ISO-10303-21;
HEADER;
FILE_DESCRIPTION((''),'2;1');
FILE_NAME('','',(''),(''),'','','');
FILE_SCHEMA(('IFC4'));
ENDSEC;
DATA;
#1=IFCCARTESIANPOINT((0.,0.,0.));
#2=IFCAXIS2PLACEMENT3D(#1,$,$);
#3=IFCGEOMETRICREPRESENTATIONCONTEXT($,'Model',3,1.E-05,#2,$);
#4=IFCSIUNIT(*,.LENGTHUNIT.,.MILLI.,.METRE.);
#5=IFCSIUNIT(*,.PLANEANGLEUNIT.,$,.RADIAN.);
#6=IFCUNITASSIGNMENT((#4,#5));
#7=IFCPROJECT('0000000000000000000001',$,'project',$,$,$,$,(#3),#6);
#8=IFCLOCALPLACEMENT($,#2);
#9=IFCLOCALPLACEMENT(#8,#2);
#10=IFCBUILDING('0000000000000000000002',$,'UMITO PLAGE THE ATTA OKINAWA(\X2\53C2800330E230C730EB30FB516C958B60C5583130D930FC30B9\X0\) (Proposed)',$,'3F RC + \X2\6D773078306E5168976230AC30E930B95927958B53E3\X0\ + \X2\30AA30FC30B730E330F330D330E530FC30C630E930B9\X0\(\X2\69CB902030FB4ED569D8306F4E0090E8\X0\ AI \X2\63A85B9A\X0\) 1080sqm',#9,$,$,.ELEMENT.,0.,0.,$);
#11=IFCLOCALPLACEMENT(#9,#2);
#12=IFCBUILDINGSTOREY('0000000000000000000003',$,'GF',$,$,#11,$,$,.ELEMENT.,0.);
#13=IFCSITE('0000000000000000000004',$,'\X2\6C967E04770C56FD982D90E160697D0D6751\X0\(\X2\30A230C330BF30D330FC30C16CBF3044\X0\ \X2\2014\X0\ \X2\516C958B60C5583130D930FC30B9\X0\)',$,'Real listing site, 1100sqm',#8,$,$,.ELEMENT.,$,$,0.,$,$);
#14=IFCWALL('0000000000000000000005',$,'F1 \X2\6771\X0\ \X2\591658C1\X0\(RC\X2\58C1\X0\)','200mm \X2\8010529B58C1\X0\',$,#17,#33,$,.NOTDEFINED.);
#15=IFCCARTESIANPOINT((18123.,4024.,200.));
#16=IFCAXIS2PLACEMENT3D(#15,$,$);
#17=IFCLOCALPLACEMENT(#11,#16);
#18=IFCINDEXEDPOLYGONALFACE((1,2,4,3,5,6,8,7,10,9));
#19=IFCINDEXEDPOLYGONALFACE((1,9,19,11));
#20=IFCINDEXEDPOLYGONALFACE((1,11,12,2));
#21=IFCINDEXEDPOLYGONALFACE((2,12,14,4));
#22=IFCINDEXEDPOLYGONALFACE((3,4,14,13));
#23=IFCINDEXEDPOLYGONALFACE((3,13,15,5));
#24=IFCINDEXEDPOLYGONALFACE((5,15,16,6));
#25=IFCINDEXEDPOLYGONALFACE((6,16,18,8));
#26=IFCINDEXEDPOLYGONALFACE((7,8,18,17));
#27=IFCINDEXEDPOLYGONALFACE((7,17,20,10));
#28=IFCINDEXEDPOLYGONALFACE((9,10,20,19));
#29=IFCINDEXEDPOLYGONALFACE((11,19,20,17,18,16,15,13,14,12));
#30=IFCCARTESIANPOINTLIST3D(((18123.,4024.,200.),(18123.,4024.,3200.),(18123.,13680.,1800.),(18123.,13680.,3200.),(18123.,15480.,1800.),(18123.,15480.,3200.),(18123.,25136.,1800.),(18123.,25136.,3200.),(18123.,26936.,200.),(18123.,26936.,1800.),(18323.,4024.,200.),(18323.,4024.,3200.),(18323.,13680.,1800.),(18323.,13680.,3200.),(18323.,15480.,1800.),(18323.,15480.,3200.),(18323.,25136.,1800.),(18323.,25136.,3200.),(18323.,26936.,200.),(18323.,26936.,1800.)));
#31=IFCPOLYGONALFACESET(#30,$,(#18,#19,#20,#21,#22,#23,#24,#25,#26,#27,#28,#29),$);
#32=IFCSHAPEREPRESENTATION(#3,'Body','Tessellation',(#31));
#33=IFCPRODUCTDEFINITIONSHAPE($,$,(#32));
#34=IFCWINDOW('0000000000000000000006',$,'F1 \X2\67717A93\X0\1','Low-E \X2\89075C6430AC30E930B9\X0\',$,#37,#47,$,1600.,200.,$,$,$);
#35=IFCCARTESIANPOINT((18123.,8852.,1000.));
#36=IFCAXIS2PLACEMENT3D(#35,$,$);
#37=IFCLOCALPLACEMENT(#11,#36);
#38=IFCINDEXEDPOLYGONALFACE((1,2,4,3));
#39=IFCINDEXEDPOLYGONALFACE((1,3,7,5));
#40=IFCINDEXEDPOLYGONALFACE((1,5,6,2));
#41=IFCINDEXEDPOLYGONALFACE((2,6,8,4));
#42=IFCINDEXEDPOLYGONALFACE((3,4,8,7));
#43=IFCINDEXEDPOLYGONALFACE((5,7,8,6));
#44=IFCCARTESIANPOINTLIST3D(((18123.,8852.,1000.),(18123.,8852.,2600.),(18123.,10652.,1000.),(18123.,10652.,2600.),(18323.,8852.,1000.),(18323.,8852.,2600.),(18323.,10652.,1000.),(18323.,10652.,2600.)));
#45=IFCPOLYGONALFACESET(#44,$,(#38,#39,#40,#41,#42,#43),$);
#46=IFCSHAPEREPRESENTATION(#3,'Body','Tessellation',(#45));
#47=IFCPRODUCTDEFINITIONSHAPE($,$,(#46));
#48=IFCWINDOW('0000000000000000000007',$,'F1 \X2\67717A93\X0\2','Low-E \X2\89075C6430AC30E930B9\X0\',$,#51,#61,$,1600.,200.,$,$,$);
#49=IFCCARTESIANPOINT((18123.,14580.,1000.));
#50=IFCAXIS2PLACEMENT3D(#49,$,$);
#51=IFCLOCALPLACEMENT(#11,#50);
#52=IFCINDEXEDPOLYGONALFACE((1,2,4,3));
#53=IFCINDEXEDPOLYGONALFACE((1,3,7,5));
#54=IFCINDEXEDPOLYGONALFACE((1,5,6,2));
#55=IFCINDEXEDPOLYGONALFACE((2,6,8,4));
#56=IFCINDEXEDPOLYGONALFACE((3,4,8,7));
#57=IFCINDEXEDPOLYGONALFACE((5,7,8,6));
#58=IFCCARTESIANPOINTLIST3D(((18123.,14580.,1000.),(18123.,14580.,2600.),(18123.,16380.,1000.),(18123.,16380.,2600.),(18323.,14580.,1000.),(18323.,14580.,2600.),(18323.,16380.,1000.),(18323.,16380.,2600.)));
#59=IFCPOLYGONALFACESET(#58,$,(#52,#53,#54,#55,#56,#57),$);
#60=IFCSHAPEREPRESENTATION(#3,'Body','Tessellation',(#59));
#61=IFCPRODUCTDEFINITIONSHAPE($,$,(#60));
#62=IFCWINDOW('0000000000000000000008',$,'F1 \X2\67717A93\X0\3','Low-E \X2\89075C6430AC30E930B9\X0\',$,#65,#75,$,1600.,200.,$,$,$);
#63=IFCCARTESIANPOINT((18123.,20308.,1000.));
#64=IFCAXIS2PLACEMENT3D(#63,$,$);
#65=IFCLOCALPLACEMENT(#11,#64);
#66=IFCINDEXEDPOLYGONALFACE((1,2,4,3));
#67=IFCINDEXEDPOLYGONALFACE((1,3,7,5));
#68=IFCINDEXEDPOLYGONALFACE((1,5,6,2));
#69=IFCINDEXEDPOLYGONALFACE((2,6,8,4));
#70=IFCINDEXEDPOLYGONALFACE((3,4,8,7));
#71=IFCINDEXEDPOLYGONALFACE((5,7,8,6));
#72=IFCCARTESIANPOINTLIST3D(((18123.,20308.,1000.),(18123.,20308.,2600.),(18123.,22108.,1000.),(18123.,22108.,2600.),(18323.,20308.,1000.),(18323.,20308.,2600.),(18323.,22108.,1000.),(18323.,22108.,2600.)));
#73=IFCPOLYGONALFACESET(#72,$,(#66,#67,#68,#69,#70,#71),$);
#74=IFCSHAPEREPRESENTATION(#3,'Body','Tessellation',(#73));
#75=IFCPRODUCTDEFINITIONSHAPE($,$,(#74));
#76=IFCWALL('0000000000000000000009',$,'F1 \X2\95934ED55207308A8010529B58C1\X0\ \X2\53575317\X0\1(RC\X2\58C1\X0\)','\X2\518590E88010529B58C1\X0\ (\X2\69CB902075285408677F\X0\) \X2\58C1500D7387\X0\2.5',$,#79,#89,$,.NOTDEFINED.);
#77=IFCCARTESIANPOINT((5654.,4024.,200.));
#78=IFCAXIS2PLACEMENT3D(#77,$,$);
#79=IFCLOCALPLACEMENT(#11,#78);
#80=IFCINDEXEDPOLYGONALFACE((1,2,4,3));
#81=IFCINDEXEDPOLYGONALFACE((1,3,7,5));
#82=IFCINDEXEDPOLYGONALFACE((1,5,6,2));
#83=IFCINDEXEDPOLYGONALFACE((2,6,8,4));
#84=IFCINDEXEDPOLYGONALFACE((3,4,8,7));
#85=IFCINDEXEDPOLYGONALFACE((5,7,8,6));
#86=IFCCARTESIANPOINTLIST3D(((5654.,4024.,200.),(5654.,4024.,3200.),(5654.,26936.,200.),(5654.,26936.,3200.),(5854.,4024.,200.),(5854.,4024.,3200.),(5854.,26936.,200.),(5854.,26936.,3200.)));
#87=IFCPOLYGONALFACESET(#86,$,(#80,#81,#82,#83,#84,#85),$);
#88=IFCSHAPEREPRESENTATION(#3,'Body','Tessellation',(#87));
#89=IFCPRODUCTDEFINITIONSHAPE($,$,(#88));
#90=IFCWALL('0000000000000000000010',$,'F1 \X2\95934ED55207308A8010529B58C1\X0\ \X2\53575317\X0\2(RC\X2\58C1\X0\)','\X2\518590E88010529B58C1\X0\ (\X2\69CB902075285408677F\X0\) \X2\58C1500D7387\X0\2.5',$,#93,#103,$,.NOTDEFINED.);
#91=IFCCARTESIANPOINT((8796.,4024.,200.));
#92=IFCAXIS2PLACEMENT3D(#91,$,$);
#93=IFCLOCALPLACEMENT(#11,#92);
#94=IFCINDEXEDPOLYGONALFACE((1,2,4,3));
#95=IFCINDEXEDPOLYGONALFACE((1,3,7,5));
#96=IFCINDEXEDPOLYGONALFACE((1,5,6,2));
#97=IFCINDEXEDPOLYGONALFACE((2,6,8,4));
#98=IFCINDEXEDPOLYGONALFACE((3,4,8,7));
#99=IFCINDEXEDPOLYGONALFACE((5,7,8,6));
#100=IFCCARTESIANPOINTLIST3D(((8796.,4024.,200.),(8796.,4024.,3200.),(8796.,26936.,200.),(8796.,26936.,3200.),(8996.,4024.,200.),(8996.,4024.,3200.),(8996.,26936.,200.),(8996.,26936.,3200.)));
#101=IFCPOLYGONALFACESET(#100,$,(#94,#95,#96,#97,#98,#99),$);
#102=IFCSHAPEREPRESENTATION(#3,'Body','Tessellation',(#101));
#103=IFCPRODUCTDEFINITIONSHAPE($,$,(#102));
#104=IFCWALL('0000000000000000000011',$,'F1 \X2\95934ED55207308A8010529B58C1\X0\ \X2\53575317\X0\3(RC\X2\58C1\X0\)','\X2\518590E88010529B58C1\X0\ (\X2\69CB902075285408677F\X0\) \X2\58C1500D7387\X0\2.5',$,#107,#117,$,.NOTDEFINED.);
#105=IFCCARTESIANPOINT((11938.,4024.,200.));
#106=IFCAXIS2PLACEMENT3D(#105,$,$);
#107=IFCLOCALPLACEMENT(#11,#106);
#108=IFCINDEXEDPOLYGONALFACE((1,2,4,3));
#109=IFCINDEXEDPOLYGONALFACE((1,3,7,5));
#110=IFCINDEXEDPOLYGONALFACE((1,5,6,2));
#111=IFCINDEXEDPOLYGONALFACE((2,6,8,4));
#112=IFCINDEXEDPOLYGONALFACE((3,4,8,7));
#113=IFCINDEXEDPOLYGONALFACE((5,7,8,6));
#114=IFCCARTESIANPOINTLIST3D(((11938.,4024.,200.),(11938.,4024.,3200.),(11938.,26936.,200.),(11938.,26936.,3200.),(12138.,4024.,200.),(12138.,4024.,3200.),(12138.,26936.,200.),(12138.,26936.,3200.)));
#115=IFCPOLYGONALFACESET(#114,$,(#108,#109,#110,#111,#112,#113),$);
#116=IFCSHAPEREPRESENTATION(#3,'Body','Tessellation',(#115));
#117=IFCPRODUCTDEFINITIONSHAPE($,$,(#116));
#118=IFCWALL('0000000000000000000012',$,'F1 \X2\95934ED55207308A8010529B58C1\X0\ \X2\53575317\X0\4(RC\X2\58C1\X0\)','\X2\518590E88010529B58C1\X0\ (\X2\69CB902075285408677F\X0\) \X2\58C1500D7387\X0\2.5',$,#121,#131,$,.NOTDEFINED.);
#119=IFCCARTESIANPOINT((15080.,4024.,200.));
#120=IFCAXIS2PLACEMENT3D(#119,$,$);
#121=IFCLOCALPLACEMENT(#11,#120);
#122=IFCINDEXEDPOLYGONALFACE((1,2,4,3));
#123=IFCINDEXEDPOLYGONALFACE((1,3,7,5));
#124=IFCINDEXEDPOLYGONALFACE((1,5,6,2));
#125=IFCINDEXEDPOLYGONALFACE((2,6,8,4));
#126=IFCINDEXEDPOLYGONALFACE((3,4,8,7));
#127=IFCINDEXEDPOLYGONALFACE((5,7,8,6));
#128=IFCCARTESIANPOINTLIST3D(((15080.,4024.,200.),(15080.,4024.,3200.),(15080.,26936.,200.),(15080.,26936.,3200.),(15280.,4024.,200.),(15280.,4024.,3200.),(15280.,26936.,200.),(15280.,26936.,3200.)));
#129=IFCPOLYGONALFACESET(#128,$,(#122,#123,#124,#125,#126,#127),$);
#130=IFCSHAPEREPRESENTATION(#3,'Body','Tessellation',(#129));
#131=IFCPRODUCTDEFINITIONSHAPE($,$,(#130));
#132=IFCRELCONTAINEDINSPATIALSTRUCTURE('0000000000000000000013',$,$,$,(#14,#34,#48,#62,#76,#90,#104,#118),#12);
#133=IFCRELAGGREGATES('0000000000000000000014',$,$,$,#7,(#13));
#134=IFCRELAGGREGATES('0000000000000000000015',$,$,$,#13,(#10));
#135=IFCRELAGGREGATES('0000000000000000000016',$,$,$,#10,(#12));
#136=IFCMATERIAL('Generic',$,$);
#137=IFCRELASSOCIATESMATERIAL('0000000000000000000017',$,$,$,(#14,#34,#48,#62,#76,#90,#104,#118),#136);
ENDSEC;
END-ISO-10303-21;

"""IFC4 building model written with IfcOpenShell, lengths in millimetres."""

from ifc_helpers import new_model, si_unit, frame, frame_2d, origin, place, context, project, spatial, rectangle, extrude, material, element, fill, save


model = new_model("IFC4")

# Units and contexts
model_context = context("Model", 3, precision=1e-05, world=origin())
ifc_project = project(units=[si_unit("LENGTHUNIT", "METRE", prefix="MILLI"), si_unit("PLANEANGLEUNIT", "RADIAN")], contexts=[model_context])

# Site, building, storey
site_placement = place(None, origin())
site = spatial("IfcSite", under=ifc_project, at=site_placement, Name="沖縄県国頭郡恩納村(アッタビーチ沿い — 公開情報ベース)", ObjectType="Real listing site, 1100sqm", CompositionType="ELEMENT", RefElevation=0.0)
building_placement = place(site_placement, origin())
building = spatial("IfcBuilding", under=site, at=building_placement, Name="UMITO PLAGE THE ATTA OKINAWA(参考モデル・公開情報ベース) (Proposed)", ObjectType="3F RC + 海への全面ガラス大開口 + オーシャンビューテラス(構造・仕様は一部 AI 推定) 1080sqm", CompositionType="ELEMENT", ElevationOfRefHeight=0.0, ElevationOfTerrain=0.0)
storey_placement = place(building_placement, origin())
storey = spatial("IfcBuildingStorey", under=building, at=storey_placement, Name="GF", CompositionType="ELEMENT", Elevation=0.0)

# Wall, openings, windows
ifc_material = material(Name="Generic")
wall_1_placement = place(storey_placement, frame((18123.0, 4024.0, 200.0)))
wall_1 = element("IfcWall", 1, at=wall_1_placement, inside=storey, material=ifc_material, Name="F1 東 外壁(RC壁)", Description="200mm 耐力壁", PredefinedType="NOTDEFINED", context=model_context, shape_type="SweptSolid", body=[
    extrude(rectangle(XDim=200.0, YDim=22912.0, at=frame_2d((100.0, 11456.0))), frame((18123.0, 4024.0, 200.0)), (0.0, 0.0, 1.0), 3000.0),
])
opening_1_placement = place(storey_placement, frame((18123.0, 8852.0, 1000.0)))
opening_1 = element("IfcOpeningElement", 2, at=opening_1_placement, cuts=wall_1, PredefinedType="NOTDEFINED", context=model_context, shape_type="SweptSolid", body=[
    extrude(rectangle(XDim=200.0, YDim=1800.0, at=frame_2d((100.0, 900.0))), frame((18123.0, 8852.0, 1000.0)), (0.0, 0.0, 1.0), 1600.0),
])
opening_2_placement = place(storey_placement, frame((18123.0, 14580.0, 1000.0)))
opening_2 = element("IfcOpeningElement", 3, at=opening_2_placement, cuts=wall_1, PredefinedType="NOTDEFINED", context=model_context, shape_type="SweptSolid", body=[
    extrude(rectangle(XDim=200.0, YDim=1800.0, at=frame_2d((100.0, 900.0))), frame((18123.0, 14580.0, 1000.0)), (0.0, 0.0, 1.0), 1600.0),
])
opening_3_placement = place(storey_placement, frame((18123.0, 20308.0, 1000.0)))
opening_3 = element("IfcOpeningElement", 4, at=opening_3_placement, cuts=wall_1, PredefinedType="NOTDEFINED", context=model_context, shape_type="SweptSolid", body=[
    extrude(rectangle(XDim=200.0, YDim=1800.0, at=frame_2d((100.0, 900.0))), frame((18123.0, 20308.0, 1000.0)), (0.0, 0.0, 1.0), 1600.0),
])
window_1_placement = place(storey_placement, frame((18123.0, 8852.0, 1000.0)))
window_1 = element("IfcWindow", 5, at=window_1_placement, inside=storey, material=ifc_material, Name="F1 東窓1", Description="Low-E 複層ガラス", OverallHeight=1600.0, OverallWidth=200.0, context=model_context, shape_type="SweptSolid", body=[
    extrude(rectangle(XDim=200.0, YDim=1800.0, at=frame_2d((100.0, 900.0))), frame((18123.0, 8852.0, 1000.0)), (0.0, 0.0, 1.0), 1600.0),
])
fill(opening_1, window_1)
window_2_placement = place(storey_placement, frame((18123.0, 14580.0, 1000.0)))
window_2 = element("IfcWindow", 6, at=window_2_placement, inside=storey, material=ifc_material, Name="F1 東窓2", Description="Low-E 複層ガラス", OverallHeight=1600.0, OverallWidth=200.0, context=model_context, shape_type="SweptSolid", body=[
    extrude(rectangle(XDim=200.0, YDim=1800.0, at=frame_2d((100.0, 900.0))), frame((18123.0, 14580.0, 1000.0)), (0.0, 0.0, 1.0), 1600.0),
])
fill(opening_2, window_2)
window_3_placement = place(storey_placement, frame((18123.0, 20308.0, 1000.0)))
window_3 = element("IfcWindow", 7, at=window_3_placement, inside=storey, material=ifc_material, Name="F1 東窓3", Description="Low-E 複層ガラス", OverallHeight=1600.0, OverallWidth=200.0, context=model_context, shape_type="SweptSolid", body=[
    extrude(rectangle(XDim=200.0, YDim=1800.0, at=frame_2d((100.0, 900.0))), frame((18123.0, 20308.0, 1000.0)), (0.0, 0.0, 1.0), 1600.0),
])
fill(opening_3, window_3)

# Walls
wall_2_placement = place(storey_placement, frame((5654.0, 4024.0, 200.0)))
element("IfcWall", 8, at=wall_2_placement, inside=storey, material=ifc_material, Name="F1 間仕切り耐力壁 南北1(RC壁)", Description="内部耐力壁 (構造用合板) 壁倍率2.5", PredefinedType="NOTDEFINED", context=model_context, shape_type="SweptSolid", body=[
    extrude(rectangle(XDim=200.0, YDim=22912.0, at=frame_2d((100.0, 11456.0))), frame((5654.0, 4024.0, 200.0)), (0.0, 0.0, 1.0), 3000.0),
])
wall_3_placement = place(storey_placement, frame((8796.0, 4024.0, 200.0)))
element("IfcWall", 9, at=wall_3_placement, inside=storey, material=ifc_material, Name="F1 間仕切り耐力壁 南北2(RC壁)", Description="内部耐力壁 (構造用合板) 壁倍率2.5", PredefinedType="NOTDEFINED", context=model_context, shape_type="SweptSolid", body=[
    extrude(rectangle(XDim=200.0, YDim=22912.0, at=frame_2d((100.0, 11456.0))), frame((8796.0, 4024.0, 200.0)), (0.0, 0.0, 1.0), 3000.0),
])
wall_4_placement = place(storey_placement, frame((11938.0, 4024.0, 200.0)))
element("IfcWall", 10, at=wall_4_placement, inside=storey, material=ifc_material, Name="F1 間仕切り耐力壁 南北3(RC壁)", Description="内部耐力壁 (構造用合板) 壁倍率2.5", PredefinedType="NOTDEFINED", context=model_context, shape_type="SweptSolid", body=[
    extrude(rectangle(XDim=200.0, YDim=22912.0, at=frame_2d((100.0, 11456.0))), frame((11938.0, 4024.0, 200.0)), (0.0, 0.0, 1.0), 3000.0),
])
wall_5_placement = place(storey_placement, frame((15080.0, 4024.0, 200.0)))
element("IfcWall", 11, at=wall_5_placement, inside=storey, material=ifc_material, Name="F1 間仕切り耐力壁 南北4(RC壁)", Description="内部耐力壁 (構造用合板) 壁倍率2.5", PredefinedType="NOTDEFINED", context=model_context, shape_type="SweptSolid", body=[
    extrude(rectangle(XDim=200.0, YDim=22912.0, at=frame_2d((100.0, 11456.0))), frame((15080.0, 4024.0, 200.0)), (0.0, 0.0, 1.0), 3000.0),
])

save(model, "model.ifc")
